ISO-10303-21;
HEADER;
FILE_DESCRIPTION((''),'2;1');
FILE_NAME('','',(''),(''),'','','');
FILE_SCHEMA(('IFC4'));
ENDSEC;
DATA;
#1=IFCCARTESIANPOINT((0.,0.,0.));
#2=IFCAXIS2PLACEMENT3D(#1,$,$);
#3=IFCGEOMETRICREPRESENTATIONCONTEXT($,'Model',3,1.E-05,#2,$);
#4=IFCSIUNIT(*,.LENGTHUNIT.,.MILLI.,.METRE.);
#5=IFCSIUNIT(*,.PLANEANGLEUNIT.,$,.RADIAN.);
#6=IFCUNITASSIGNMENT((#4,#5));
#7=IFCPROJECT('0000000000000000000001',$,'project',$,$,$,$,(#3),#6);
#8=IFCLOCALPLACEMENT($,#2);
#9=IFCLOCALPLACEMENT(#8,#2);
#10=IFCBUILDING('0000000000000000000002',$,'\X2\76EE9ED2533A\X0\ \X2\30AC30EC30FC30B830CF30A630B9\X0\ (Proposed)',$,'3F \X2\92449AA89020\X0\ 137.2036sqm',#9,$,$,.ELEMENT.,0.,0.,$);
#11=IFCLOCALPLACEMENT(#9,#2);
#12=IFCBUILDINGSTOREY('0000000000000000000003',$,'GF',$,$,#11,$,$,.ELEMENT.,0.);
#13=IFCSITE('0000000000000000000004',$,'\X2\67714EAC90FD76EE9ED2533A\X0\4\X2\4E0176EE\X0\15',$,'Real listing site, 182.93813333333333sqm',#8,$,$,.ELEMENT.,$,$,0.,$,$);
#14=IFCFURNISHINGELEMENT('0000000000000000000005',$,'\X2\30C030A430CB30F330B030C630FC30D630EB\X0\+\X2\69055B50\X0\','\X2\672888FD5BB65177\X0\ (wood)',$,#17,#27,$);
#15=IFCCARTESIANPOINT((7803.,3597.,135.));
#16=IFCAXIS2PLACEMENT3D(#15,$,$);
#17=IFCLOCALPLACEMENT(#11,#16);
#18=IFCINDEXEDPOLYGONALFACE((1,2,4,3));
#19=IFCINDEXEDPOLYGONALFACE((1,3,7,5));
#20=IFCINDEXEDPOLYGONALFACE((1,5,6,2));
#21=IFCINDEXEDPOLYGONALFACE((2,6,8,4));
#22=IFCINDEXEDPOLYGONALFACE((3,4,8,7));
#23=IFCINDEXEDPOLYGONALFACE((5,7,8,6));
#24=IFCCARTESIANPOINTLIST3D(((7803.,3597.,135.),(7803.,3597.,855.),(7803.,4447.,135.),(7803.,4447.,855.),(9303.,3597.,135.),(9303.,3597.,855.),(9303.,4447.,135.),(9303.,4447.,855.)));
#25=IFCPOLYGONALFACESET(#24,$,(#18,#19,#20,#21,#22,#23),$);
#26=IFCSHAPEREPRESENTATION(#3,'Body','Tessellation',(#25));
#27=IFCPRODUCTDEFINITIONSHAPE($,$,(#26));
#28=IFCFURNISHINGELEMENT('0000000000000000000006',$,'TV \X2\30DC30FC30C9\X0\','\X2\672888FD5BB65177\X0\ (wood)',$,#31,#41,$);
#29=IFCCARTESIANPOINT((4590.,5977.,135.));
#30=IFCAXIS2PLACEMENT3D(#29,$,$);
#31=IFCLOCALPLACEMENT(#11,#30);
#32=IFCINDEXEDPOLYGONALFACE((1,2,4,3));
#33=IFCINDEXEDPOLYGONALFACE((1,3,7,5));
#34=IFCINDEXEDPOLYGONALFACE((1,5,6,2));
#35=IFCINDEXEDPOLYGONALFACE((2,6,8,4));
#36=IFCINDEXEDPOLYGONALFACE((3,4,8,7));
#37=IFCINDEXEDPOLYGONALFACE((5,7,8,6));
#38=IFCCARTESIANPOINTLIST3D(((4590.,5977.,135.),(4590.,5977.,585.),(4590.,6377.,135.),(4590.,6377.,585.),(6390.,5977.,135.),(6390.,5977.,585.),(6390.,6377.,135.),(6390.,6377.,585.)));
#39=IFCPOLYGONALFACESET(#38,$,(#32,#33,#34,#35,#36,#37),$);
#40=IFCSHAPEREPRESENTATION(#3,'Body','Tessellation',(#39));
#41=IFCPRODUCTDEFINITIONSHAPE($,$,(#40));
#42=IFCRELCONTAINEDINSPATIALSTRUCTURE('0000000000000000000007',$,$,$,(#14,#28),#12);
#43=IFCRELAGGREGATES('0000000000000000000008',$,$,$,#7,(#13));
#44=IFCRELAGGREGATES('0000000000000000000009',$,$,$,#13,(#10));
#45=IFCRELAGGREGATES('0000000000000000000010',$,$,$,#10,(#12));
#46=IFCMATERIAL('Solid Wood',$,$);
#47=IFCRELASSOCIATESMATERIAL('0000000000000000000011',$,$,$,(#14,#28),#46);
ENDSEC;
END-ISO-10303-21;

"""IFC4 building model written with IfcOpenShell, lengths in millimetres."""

from ifc_helpers import new_model, si_unit, frame, frame_2d, origin, place, context, project, spatial, rectangle, extrude, material, element, save


model = new_model("IFC4")

# Units and contexts
model_context = context("Model", 3, precision=1e-05, world=origin())
ifc_project = project(units=[si_unit("LENGTHUNIT", "METRE", prefix="MILLI"), si_unit("PLANEANGLEUNIT", "RADIAN")], contexts=[model_context])

# Site, building, storey
site_placement = place(None, origin())
site = spatial("IfcSite", under=ifc_project, at=site_placement, Name="東京都目黒区4丁目15", ObjectType="Real listing site, 182.93813333333333sqm", CompositionType="ELEMENT", RefElevation=0.0)
building_placement = place(site_placement, origin())
building = spatial("IfcBuilding", under=site, at=building_placement, Name="目黒区 ガレージハウス (Proposed)", ObjectType="3F 鉄骨造 137.2036sqm", CompositionType="ELEMENT", ElevationOfRefHeight=0.0, ElevationOfTerrain=0.0)
storey_placement = place(building_placement, origin())
storey = spatial("IfcBuildingStorey", under=building, at=storey_placement, Name="GF", CompositionType="ELEMENT", Elevation=0.0)

# Shared definitions
ifc_material_1 = material(Name="Solid Wood")

# Furnishing elements
furnishing_1_placement = place(storey_placement, frame((7803.0, 3597.0, 135.0)))
element("IfcFurnishingElement", 1, at=furnishing_1_placement, inside=storey, material=ifc_material_1, Name="ダイニングテーブル+椅子", Description="木製家具 (wood)", context=model_context, shape_type="SweptSolid", body=[
    extrude(rectangle(XDim=1500.0, YDim=850.0, at=frame_2d((750.0, 425.0))), frame((7803.0, 3597.0, 135.0)), (0.0, 0.0, 1.0), 720.0),
])
furnishing_2_placement = place(storey_placement, frame((4590.0, 5977.0, 135.0)))
element("IfcFurnishingElement", 2, at=furnishing_2_placement, inside=storey, material=ifc_material_1, Name="TV ボード", Description="木製家具 (wood)", context=model_context, shape_type="SweptSolid", body=[
    extrude(rectangle(XDim=1800.0, YDim=400.0, at=frame_2d((900.0, 200.0))), frame((4590.0, 5977.0, 135.0)), (0.0, 0.0, 1.0), 450.0),
])

save(model, "model.ifc")
